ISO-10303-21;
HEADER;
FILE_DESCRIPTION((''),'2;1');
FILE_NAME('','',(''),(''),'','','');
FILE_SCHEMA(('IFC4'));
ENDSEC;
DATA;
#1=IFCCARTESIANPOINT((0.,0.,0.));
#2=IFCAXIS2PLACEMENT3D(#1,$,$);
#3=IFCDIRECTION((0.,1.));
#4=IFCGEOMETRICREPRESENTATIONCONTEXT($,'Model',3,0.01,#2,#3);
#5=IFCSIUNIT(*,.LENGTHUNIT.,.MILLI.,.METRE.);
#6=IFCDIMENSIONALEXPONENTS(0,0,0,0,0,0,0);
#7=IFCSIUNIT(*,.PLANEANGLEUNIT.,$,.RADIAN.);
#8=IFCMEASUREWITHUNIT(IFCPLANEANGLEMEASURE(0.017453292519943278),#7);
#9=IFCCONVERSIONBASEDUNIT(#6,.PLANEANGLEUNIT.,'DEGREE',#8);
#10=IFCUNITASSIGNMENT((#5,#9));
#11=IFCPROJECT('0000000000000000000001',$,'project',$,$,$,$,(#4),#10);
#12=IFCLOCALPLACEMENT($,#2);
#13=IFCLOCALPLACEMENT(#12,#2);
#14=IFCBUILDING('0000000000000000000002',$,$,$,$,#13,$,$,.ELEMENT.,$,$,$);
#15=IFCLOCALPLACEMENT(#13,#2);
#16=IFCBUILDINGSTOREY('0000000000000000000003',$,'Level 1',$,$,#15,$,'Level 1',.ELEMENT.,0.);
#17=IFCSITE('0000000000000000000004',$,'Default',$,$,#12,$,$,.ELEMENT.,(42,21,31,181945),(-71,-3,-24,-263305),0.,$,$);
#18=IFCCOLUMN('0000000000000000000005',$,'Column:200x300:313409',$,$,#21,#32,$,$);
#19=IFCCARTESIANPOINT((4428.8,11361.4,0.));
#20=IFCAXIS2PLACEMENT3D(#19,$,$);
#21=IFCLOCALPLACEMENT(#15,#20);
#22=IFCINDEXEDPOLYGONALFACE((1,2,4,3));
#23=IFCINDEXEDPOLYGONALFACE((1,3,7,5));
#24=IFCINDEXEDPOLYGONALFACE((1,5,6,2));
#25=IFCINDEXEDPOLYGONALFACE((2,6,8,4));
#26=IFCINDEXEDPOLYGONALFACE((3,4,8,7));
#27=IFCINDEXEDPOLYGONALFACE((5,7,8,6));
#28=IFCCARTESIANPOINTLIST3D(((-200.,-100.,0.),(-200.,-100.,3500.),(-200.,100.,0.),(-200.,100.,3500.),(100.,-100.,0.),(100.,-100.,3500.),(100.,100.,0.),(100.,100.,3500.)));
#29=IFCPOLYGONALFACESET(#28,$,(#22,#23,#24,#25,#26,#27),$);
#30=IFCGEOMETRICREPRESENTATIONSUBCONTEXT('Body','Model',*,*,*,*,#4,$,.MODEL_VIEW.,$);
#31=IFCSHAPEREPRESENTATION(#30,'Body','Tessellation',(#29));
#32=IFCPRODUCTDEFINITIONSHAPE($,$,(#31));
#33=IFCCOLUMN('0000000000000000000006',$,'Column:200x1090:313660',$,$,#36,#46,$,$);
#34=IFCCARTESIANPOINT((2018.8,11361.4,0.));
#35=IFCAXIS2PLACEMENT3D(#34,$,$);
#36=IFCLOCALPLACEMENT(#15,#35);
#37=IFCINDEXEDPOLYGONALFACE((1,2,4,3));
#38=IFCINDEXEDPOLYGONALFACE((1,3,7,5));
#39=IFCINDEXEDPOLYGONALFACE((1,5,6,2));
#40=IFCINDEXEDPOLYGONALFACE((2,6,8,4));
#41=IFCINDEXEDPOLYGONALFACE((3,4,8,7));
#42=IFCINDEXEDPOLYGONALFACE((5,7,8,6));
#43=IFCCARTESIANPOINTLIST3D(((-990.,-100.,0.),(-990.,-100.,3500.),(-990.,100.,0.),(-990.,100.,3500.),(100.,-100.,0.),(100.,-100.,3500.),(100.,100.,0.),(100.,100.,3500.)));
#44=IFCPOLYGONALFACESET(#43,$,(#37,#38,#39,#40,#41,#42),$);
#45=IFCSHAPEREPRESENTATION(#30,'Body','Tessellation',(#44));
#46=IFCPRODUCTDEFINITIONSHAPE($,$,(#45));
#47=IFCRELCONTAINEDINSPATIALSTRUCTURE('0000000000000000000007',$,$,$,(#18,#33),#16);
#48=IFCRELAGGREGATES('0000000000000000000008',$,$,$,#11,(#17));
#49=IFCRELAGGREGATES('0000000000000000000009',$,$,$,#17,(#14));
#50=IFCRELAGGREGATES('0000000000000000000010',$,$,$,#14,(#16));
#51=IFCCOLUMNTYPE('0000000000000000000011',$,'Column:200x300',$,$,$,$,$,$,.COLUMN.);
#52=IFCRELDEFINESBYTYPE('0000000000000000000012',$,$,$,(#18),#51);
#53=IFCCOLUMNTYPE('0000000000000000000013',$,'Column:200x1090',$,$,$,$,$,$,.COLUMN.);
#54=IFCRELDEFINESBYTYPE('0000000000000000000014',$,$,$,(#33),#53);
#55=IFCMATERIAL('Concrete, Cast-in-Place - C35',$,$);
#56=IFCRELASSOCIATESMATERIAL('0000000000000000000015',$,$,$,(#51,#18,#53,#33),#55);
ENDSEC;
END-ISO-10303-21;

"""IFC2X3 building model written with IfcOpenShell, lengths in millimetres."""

from ifc_helpers import new_model, entity, si_unit, converted_unit, direction, frame, frame_2d, origin, origin_2d_with_axis, place, context, subcontext, project, spatial, rectangle, extrude, source, transform, mapped, material, type_object, type_shapes, element, save


model = new_model("IFC2X3")

# Units and contexts
model_context = context("Model", 3, precision=0.01, world=origin(), true_north=direction((0.0, 1.0)))
body_context = subcontext(model_context, "Body", "Model", "MODEL_VIEW")
ifc_project = project(units=[si_unit("LENGTHUNIT", "METRE", prefix="MILLI"), converted_unit("PLANEANGLEUNIT", "DEGREE", entity("IfcPlaneAngleMeasure", 0.017453292519943278), si_unit("PLANEANGLEUNIT", "RADIAN"), dimensions=[0, 0, 0, 0, 0, 0, 0])], contexts=[model_context])

# Site, building, storey
site_placement = place(None, origin())
site = spatial("IfcSite", under=ifc_project, at=site_placement, Name="Default", CompositionType="ELEMENT", RefLatitude=(42, 21, 31, 181945), RefLongitude=(-71, -3, -24, -263305), RefElevation=0.0)
building_placement = place(site_placement, origin())
building = spatial("IfcBuilding", under=site, at=building_placement, CompositionType="ELEMENT")
storey_placement = place(building_placement, origin())
storey = spatial("IfcBuildingStorey", under=building, at=storey_placement, Name="Level 1", LongName="Level 1", CompositionType="ELEMENT", Elevation=0.0)

# Columns
ifc_material_1 = material(Name="Concrete, Cast-in-Place - C35")
column_type_1 = type_object("IfcColumnType", Name="Column:200x300", PredefinedType="COLUMN", material=ifc_material_1)
shared_shape_1 = source(origin(), body_context, "Body", "SweptSolid", [
    extrude(rectangle(XDim=300.0, YDim=200.0, at=origin_2d_with_axis()), frame((-50.0, 0.0, 0.0), z_axis=(0.0, 0.0, 1.0), x_axis=(-1.0, 0.0, 0.0)), (0.0, 0.0, 1.0), 3500.0),
])
type_shapes(column_type_1, [shared_shape_1])
column_1_placement = place(storey_placement, frame((4428.8, 11361.4, 0.0)))
element("IfcColumn", 1, at=column_1_placement, inside=storey, type_object=column_type_1, material=ifc_material_1, Name="Column:200x300:313409", context=body_context, shape_type="MappedRepresentation", body=[
    mapped(shared_shape_1, transform((0.0, 0.0, 0.0), scale=1.0)),
])
column_type_2 = type_object("IfcColumnType", Name="Column:200x1090", PredefinedType="COLUMN", material=ifc_material_1)
shared_shape_2 = source(origin(), body_context, "Body", "SweptSolid", [
    extrude(rectangle(XDim=1090.0, YDim=200.0, at=frame_2d((0.0, 0.0), x_axis=(1.0, 0.0))), frame((-445.0, 0.0, 0.0), z_axis=(0.0, 0.0, 1.0), x_axis=(-1.0, 0.0, 0.0)), (0.0, 0.0, 1.0), 3500.0),
])
type_shapes(column_type_2, [shared_shape_2])
column_2_placement = place(storey_placement, frame((2018.8, 11361.4, 0.0)))
element("IfcColumn", 2, at=column_2_placement, inside=storey, type_object=column_type_2, material=ifc_material_1, Name="Column:200x1090:313660", context=body_context, shape_type="MappedRepresentation", body=[
    mapped(shared_shape_2, transform((0.0, 0.0, 0.0), scale=1.0)),
])

save(model, "model.ifc")
